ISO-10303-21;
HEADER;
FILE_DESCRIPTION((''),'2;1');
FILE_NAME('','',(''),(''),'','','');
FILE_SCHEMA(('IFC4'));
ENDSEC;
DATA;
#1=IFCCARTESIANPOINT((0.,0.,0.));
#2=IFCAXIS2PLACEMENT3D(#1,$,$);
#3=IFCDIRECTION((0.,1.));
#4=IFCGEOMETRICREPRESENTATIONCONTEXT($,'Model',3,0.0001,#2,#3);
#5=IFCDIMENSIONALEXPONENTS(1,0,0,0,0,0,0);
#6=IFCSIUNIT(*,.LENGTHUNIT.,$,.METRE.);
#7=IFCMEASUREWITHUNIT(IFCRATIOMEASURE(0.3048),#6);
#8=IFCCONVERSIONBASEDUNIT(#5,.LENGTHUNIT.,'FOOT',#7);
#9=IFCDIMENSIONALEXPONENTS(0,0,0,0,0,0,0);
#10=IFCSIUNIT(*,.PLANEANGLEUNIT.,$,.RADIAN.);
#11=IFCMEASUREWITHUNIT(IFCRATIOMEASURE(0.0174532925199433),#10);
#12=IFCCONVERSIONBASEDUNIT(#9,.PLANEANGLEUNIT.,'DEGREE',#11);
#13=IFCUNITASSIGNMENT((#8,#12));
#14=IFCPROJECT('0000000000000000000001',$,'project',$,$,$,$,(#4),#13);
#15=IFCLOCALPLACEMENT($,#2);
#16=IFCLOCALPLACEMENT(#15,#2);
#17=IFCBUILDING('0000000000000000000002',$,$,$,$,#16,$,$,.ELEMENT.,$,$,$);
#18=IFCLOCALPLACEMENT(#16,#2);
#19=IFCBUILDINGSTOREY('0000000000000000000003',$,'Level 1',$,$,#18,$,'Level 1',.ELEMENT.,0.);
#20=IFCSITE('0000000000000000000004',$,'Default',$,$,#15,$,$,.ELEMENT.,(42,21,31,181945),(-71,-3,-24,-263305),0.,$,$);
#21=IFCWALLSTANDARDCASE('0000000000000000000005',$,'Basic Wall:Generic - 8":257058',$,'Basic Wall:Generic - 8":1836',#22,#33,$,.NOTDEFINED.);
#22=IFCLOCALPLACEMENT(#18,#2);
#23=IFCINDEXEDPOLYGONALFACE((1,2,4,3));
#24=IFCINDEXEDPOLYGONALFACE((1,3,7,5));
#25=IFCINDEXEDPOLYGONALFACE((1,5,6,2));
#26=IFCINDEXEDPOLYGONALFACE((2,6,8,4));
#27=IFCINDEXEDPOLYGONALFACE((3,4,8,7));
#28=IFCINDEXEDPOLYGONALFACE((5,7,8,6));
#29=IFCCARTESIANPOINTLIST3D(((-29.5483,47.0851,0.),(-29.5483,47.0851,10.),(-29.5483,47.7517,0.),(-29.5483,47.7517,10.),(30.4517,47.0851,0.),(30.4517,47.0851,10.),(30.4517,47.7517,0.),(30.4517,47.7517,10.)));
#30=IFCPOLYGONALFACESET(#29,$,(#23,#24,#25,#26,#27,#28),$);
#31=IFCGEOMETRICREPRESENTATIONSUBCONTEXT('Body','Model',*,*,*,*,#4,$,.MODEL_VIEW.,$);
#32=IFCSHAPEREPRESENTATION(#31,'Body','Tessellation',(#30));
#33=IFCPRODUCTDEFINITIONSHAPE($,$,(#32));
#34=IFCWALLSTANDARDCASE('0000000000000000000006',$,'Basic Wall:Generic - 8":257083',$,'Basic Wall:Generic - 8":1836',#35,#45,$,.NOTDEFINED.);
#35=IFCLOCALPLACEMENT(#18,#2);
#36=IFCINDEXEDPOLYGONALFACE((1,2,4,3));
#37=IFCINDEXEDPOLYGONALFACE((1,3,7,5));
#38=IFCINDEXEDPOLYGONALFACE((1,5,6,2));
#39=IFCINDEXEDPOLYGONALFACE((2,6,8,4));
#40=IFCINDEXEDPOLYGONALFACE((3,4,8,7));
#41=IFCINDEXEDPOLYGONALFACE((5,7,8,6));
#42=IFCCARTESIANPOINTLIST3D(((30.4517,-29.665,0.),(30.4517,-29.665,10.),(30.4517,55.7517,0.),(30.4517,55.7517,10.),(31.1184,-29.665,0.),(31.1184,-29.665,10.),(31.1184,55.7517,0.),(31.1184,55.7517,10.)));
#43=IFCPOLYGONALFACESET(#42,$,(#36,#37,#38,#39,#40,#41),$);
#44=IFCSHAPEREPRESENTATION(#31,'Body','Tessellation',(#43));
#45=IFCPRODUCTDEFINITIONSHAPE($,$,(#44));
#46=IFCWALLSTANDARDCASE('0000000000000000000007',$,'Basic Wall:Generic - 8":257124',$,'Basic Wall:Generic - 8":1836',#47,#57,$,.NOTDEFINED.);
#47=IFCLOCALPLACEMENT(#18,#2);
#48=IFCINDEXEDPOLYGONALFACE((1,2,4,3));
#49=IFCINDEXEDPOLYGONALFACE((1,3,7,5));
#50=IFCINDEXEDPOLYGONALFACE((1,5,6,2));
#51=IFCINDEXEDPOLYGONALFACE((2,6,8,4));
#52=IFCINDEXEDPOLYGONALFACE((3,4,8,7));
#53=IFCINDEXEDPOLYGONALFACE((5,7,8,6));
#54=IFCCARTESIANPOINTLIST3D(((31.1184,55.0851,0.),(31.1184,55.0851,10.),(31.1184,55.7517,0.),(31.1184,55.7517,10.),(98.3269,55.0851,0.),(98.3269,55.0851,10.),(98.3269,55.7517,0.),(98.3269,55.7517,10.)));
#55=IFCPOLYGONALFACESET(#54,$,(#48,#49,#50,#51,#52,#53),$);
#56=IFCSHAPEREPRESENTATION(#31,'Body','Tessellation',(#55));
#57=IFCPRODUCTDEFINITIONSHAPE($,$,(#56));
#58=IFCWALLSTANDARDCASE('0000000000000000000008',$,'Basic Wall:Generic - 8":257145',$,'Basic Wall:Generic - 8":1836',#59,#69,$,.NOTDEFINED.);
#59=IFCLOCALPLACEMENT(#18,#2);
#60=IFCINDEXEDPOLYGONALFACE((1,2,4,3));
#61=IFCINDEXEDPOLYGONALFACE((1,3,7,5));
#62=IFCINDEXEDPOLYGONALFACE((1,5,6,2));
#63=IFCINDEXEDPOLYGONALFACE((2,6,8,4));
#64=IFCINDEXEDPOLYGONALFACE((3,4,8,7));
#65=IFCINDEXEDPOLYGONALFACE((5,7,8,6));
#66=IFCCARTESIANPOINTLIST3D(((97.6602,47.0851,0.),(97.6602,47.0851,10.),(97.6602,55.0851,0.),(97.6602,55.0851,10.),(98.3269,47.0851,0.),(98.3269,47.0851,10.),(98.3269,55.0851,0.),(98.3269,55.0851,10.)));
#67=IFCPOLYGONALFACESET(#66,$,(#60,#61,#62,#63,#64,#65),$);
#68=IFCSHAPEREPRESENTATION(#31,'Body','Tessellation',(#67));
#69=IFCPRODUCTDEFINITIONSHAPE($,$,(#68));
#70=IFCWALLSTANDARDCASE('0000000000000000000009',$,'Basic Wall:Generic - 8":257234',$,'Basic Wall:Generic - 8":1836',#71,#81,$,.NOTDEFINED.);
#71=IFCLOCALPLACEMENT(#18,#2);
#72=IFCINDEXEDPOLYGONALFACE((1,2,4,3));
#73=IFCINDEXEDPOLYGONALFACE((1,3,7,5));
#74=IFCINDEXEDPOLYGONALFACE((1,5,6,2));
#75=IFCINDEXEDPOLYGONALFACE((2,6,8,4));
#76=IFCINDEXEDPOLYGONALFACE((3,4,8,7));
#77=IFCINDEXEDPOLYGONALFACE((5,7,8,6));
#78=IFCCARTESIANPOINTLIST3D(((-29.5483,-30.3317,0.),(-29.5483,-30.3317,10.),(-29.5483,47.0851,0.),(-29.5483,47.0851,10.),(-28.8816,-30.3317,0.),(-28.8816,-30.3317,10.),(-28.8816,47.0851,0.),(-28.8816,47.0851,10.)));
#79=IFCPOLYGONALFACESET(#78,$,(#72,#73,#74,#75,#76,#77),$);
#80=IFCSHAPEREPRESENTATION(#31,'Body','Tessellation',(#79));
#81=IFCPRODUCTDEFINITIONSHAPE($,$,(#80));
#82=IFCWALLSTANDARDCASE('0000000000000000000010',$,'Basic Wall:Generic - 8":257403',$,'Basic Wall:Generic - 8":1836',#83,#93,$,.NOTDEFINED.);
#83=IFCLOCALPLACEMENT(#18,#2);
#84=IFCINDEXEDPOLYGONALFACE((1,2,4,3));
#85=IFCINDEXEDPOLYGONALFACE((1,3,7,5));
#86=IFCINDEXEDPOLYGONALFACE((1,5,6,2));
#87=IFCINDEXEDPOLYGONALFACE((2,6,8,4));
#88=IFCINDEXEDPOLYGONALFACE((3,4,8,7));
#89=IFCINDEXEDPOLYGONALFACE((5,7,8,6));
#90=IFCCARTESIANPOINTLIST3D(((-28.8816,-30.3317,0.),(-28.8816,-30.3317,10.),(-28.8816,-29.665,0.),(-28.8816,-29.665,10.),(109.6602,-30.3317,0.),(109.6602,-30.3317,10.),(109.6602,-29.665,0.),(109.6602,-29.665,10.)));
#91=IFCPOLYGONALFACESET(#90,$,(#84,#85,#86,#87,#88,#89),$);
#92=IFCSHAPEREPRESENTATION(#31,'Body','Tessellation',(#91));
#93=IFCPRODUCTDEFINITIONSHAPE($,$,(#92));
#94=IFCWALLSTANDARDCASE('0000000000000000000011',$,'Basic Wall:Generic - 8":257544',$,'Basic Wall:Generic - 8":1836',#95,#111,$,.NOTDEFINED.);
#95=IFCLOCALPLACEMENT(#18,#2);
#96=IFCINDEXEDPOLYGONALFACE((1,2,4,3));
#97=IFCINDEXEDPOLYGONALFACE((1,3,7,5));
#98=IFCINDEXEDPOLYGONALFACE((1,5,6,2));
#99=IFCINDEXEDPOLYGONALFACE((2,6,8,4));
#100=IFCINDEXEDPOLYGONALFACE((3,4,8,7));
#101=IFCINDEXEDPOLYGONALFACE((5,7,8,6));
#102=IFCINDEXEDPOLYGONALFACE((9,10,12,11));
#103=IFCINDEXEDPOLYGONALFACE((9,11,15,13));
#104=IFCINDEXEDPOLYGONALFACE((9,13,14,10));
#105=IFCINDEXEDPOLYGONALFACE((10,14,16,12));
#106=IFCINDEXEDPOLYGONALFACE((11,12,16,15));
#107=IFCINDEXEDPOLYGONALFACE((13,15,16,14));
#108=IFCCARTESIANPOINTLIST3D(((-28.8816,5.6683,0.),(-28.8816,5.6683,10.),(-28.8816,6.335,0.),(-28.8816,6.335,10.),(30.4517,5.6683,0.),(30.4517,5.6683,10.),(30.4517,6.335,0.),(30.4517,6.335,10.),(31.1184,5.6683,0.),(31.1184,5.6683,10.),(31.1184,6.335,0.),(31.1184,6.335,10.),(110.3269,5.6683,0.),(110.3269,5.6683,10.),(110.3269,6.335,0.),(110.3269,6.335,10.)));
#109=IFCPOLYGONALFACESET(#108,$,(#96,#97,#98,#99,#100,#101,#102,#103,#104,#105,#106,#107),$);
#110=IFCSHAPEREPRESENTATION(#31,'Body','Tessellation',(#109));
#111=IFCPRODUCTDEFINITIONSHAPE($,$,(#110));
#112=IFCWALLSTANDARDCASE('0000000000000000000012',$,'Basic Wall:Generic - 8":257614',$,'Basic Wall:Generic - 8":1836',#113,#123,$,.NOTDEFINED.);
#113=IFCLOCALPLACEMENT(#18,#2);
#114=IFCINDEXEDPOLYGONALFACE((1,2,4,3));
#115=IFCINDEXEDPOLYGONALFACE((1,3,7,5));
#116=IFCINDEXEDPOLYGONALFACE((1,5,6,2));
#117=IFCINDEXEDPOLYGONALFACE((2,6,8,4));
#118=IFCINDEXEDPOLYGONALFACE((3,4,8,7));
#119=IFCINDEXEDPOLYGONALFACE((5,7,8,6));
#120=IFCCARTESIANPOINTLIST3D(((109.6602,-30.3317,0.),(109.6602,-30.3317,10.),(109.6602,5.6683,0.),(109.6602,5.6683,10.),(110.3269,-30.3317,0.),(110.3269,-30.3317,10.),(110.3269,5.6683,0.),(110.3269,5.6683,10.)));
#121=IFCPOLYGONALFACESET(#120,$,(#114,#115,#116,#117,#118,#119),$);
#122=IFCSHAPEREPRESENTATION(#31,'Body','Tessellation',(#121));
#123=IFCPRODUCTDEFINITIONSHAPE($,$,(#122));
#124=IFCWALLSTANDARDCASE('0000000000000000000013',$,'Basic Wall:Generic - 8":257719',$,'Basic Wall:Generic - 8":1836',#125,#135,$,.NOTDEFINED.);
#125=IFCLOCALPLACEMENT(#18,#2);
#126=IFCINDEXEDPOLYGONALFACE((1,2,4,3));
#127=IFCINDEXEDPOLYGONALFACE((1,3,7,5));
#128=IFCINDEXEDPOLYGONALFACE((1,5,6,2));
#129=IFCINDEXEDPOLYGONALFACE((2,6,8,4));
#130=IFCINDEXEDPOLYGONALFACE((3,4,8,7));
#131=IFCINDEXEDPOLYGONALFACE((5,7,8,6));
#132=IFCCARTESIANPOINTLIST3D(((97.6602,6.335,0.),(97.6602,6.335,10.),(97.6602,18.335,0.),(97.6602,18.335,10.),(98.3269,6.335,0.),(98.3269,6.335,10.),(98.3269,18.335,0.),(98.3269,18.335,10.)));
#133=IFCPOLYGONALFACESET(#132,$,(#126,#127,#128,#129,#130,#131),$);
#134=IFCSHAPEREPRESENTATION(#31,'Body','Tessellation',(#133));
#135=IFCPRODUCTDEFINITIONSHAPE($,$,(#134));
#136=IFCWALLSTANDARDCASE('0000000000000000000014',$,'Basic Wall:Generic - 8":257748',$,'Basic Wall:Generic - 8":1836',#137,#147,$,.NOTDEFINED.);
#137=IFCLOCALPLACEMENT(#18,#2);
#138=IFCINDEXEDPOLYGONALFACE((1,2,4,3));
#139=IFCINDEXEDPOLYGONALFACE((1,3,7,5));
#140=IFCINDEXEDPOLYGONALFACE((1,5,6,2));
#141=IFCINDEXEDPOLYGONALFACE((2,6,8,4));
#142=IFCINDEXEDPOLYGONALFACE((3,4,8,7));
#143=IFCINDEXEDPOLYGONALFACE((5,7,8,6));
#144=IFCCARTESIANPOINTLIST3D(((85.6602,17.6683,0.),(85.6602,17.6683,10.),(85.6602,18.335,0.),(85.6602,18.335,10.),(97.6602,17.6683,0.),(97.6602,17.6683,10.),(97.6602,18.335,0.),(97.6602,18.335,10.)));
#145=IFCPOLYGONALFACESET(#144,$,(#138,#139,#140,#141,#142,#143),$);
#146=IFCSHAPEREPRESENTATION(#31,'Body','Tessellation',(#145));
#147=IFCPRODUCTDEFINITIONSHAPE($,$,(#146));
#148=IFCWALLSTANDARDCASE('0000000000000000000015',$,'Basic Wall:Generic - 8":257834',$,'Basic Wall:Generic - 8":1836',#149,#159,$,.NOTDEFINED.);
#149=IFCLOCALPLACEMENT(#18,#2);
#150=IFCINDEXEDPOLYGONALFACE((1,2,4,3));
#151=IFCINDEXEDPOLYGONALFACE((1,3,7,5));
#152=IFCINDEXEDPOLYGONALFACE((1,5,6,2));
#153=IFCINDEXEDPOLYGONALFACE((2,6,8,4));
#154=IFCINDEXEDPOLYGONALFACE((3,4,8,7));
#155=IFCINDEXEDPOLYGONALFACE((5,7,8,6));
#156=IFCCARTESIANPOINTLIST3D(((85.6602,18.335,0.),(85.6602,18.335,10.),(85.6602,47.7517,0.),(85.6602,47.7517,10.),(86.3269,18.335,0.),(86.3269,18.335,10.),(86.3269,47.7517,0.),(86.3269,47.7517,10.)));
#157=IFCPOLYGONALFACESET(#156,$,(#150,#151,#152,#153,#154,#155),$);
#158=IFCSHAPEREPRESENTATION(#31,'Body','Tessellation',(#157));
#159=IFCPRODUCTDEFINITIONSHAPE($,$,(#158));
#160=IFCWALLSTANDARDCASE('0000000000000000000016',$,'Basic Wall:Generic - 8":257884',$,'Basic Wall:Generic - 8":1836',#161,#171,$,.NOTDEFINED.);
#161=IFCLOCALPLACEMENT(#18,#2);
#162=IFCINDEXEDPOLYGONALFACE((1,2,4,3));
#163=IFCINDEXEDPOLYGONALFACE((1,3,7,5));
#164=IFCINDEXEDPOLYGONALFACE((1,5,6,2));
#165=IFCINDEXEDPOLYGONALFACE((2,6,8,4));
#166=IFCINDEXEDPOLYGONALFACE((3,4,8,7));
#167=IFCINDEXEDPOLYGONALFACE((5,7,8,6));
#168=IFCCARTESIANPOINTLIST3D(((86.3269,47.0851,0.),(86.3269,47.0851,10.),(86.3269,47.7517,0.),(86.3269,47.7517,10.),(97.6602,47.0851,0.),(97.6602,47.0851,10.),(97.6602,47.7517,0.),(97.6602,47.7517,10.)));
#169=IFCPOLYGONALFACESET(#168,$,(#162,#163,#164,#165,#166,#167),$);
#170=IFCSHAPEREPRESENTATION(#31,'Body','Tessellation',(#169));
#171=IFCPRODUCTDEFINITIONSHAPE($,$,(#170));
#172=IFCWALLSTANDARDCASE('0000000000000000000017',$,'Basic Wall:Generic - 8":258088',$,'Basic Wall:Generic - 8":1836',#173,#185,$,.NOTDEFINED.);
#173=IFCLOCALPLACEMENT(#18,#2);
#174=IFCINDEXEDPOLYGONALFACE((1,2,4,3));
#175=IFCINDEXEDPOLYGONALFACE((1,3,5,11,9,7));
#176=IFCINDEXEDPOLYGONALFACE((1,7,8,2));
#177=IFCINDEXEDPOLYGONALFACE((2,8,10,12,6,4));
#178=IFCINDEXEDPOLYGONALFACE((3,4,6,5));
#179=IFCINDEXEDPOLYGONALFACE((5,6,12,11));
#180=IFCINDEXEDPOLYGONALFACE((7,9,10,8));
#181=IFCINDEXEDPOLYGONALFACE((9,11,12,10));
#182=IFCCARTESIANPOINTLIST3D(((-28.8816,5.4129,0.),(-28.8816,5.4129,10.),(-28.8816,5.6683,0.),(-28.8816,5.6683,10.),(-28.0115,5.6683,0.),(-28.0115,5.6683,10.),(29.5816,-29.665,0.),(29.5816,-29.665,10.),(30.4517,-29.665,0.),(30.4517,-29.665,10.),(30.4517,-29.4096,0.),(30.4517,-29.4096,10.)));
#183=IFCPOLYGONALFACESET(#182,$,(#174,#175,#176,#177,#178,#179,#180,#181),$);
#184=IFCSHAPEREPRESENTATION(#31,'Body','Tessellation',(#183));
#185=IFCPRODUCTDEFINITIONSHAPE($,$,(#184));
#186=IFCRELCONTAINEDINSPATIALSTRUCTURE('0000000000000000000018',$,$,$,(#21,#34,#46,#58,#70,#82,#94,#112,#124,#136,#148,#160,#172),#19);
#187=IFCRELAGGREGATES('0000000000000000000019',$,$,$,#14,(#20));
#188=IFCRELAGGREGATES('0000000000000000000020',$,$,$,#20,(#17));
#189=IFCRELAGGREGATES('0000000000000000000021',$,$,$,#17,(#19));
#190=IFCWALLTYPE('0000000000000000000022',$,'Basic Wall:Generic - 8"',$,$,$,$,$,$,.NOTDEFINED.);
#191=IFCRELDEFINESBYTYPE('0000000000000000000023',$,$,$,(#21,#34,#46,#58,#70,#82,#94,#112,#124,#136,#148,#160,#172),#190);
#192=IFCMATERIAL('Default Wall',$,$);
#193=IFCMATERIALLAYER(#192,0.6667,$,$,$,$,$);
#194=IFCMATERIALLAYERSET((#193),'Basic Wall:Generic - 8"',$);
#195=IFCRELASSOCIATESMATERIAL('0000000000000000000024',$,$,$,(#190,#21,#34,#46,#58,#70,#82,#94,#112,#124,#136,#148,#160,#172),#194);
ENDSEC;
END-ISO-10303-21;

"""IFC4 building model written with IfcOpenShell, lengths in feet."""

from ifc_helpers import new_model, entity, si_unit, converted_unit, direction, frame, frame_2d, origin, place, context, subcontext, project, spatial, polyline, rectangle, outline, extrude, material, layer, layer_set, layer_usage, type_object, element, save


model = new_model("IFC4")

# Units and contexts
model_context = context("Model", 3, precision=0.0001, world=origin(), true_north=direction((0.0, 1.0)))
body_context = subcontext(model_context, "Body", "Model", "MODEL_VIEW")
ifc_project = project(units=[converted_unit("LENGTHUNIT", "FOOT", entity("IfcRatioMeasure", 0.3048), si_unit("LENGTHUNIT", "METRE"), dimensions=[1, 0, 0, 0, 0, 0, 0]), converted_unit("PLANEANGLEUNIT", "DEGREE", entity("IfcRatioMeasure", 0.0174532925199433), si_unit("PLANEANGLEUNIT", "RADIAN"), dimensions=[0, 0, 0, 0, 0, 0, 0])], contexts=[model_context])

# Site, building, storey
site_placement = place(None, origin())
site = spatial("IfcSite", under=ifc_project, at=site_placement, Name="Default", CompositionType="ELEMENT", RefLatitude=(42, 21, 31, 181945), RefLongitude=(-71, -3, -24, -263305), RefElevation=0.0)
building_placement = place(site_placement, origin())
building = spatial("IfcBuilding", under=site, at=building_placement, CompositionType="ELEMENT")
storey_placement = place(building_placement, origin())
storey = spatial("IfcBuildingStorey", under=building, at=storey_placement, Name="Level 1", LongName="Level 1", CompositionType="ELEMENT", Elevation=0.0)

# Walls
ifc_material = material(Name="Default Wall")
ifc_layer = layer(ifc_material, 0.6667)
ifc_layer_set = layer_set([ifc_layer], Name="Basic Wall:Generic - 8\"")
ifc_layer_usage_1 = layer_usage(ifc_layer_set, "AXIS2", "NEGATIVE", 0.3333)
wall_type = type_object("IfcWallType", Name="Basic Wall:Generic - 8\"", PredefinedType="NOTDEFINED", material=ifc_layer_set)
wall_1_placement = place(storey_placement, frame((-29.5483, 47.4184, 0.0)))
element("IfcWallStandardCase", 1, at=wall_1_placement, inside=storey, type_object=wall_type, material=ifc_layer_usage_1, Name="Basic Wall:Generic - 8\":257058", ObjectType="Basic Wall:Generic - 8\":1836", PredefinedType="NOTDEFINED", context=body_context, shape_type="SweptSolid", body=[
    extrude(rectangle(XDim=60.0, YDim=0.6667, at=frame_2d((30.0, 0.0), x_axis=(-1.0, 0.0))), origin(), (0.0, 0.0, 1.0), 10.0),
])
ifc_layer_usage_2 = layer_usage(ifc_layer_set, "AXIS2", "NEGATIVE", 0.3333)
wall_2_placement = place(storey_placement, frame((30.785, -29.665, 0.0), z_axis=(0.0, 0.0, 1.0), x_axis=(0.0, 1.0, 0.0)))
element("IfcWallStandardCase", 2, at=wall_2_placement, inside=storey, type_object=wall_type, material=ifc_layer_usage_2, Name="Basic Wall:Generic - 8\":257083", ObjectType="Basic Wall:Generic - 8\":1836", PredefinedType="NOTDEFINED", context=body_context, shape_type="SweptSolid", body=[
    extrude(rectangle(XDim=85.4167, YDim=0.6667, at=frame_2d((42.7084, 0.0), x_axis=(-1.0, 0.0))), origin(), (0.0, 0.0, 1.0), 10.0),
])
ifc_layer_usage_3 = layer_usage(ifc_layer_set, "AXIS2", "NEGATIVE", 0.3333)
wall_3_placement = place(storey_placement, frame((31.1184, 55.4184, 0.0)))
element("IfcWallStandardCase", 3, at=wall_3_placement, inside=storey, type_object=wall_type, material=ifc_layer_usage_3, Name="Basic Wall:Generic - 8\":257124", ObjectType="Basic Wall:Generic - 8\":1836", PredefinedType="NOTDEFINED", context=body_context, shape_type="SweptSolid", body=[
    extrude(rectangle(XDim=67.2085, YDim=0.6667, at=frame_2d((33.6043, 0.0), x_axis=(-1.0, 0.0))), origin(), (0.0, 0.0, 1.0), 10.0),
])
ifc_layer_usage_4 = layer_usage(ifc_layer_set, "AXIS2", "NEGATIVE", 0.3333)
wall_4_placement = place(storey_placement, frame((97.9936, 55.0851, 0.0), z_axis=(0.0, 0.0, 1.0), x_axis=(0.0, -1.0, 0.0)))
element("IfcWallStandardCase", 4, at=wall_4_placement, inside=storey, type_object=wall_type, material=ifc_layer_usage_4, Name="Basic Wall:Generic - 8\":257145", ObjectType="Basic Wall:Generic - 8\":1836", PredefinedType="NOTDEFINED", context=body_context, shape_type="SweptSolid", body=[
    extrude(rectangle(XDim=8.0, YDim=0.6667, at=frame_2d((4.0, 0.0), x_axis=(-1.0, 0.0))), origin(), (0.0, 0.0, 1.0), 10.0),
])
ifc_layer_usage_5 = layer_usage(ifc_layer_set, "AXIS2", "NEGATIVE", 0.3333)
wall_5_placement = place(storey_placement, frame((-29.215, -30.3317, 0.0), z_axis=(0.0, 0.0, 1.0), x_axis=(0.0, 1.0, 0.0)))
element("IfcWallStandardCase", 5, at=wall_5_placement, inside=storey, type_object=wall_type, material=ifc_layer_usage_5, Name="Basic Wall:Generic - 8\":257234", ObjectType="Basic Wall:Generic - 8\":1836", PredefinedType="NOTDEFINED", context=body_context, shape_type="SweptSolid", body=[
    extrude(rectangle(XDim=77.4167, YDim=0.6667, at=frame_2d((38.7084, 0.0), x_axis=(-1.0, 0.0))), origin(), (0.0, 0.0, 1.0), 10.0),
])
ifc_layer_usage_6 = layer_usage(ifc_layer_set, "AXIS2", "NEGATIVE", 0.3333)
wall_6_placement = place(storey_placement, frame((-28.8816, -29.9983, 0.0)))
element("IfcWallStandardCase", 6, at=wall_6_placement, inside=storey, type_object=wall_type, material=ifc_layer_usage_6, Name="Basic Wall:Generic - 8\":257403", ObjectType="Basic Wall:Generic - 8\":1836", PredefinedType="NOTDEFINED", context=body_context, shape_type="SweptSolid", body=[
    extrude(rectangle(XDim=138.5419, YDim=0.6667, at=frame_2d((69.2709, 0.0), x_axis=(-1.0, 0.0))), origin(), (0.0, 0.0, 1.0), 10.0),
])

# Wall, opening
ifc_layer_usage_7 = layer_usage(ifc_layer_set, "AXIS2", "NEGATIVE", 0.3333)
wall_7_placement = place(storey_placement, frame((-28.8816, 6.0017, 0.0)))
wall_7 = element("IfcWallStandardCase", 7, at=wall_7_placement, inside=storey, type_object=wall_type, material=ifc_layer_usage_7, Name="Basic Wall:Generic - 8\":257544", ObjectType="Basic Wall:Generic - 8\":1836", PredefinedType="NOTDEFINED", context=body_context, shape_type="SweptSolid", body=[
    extrude(rectangle(XDim=139.2085, YDim=0.6667, at=frame_2d((69.6043, 0.0), x_axis=(-1.0, 0.0))), origin(), (0.0, 0.0, 1.0), 10.0),
])
opening_placement = place(storey_placement, frame((-28.8816, 6.0017, 0.0)))
element("IfcOpeningElement", 8, at=opening_placement, cuts=wall_7, ObjectType="Opening", PredefinedType="OPENING", context=body_context, shape_type="SweptSolid", body=[
    extrude(rectangle(XDim=10.0, YDim=0.6667, at=frame_2d((0.0, 0.0), x_axis=(1.0, 0.0))), frame((59.3333, 0.0, 5.0), z_axis=(1.0, 0.0, 0.0), x_axis=(0.0, 0.0, -1.0)), (0.0, 0.0, 1.0), 0.6667),
])

# Walls
ifc_layer_usage_8 = layer_usage(ifc_layer_set, "AXIS2", "NEGATIVE", 0.3333)
wall_8_placement = place(storey_placement, frame((109.9936, 5.6683, 0.0), z_axis=(0.0, 0.0, 1.0), x_axis=(0.0, -1.0, 0.0)))
element("IfcWallStandardCase", 9, at=wall_8_placement, inside=storey, type_object=wall_type, material=ifc_layer_usage_8, Name="Basic Wall:Generic - 8\":257614", ObjectType="Basic Wall:Generic - 8\":1836", PredefinedType="NOTDEFINED", context=body_context, shape_type="SweptSolid", body=[
    extrude(rectangle(XDim=36.0, YDim=0.6667, at=frame_2d((18.0, 0.0), x_axis=(-1.0, 0.0))), origin(), (0.0, 0.0, 1.0), 10.0),
])
ifc_layer_usage_9 = layer_usage(ifc_layer_set, "AXIS2", "NEGATIVE", 0.3333)
wall_9_placement = place(storey_placement, frame((97.9936, 6.335, 0.0), z_axis=(0.0, 0.0, 1.0), x_axis=(0.0, 1.0, 0.0)))
element("IfcWallStandardCase", 10, at=wall_9_placement, inside=storey, type_object=wall_type, material=ifc_layer_usage_9, Name="Basic Wall:Generic - 8\":257719", ObjectType="Basic Wall:Generic - 8\":1836", PredefinedType="NOTDEFINED", context=body_context, shape_type="SweptSolid", body=[
    extrude(rectangle(XDim=12.0, YDim=0.6667, at=frame_2d((6.0, 0.0), x_axis=(-1.0, 0.0))), origin(), (0.0, 0.0, 1.0), 10.0),
])
ifc_layer_usage_10 = layer_usage(ifc_layer_set, "AXIS2", "NEGATIVE", 0.3333)
wall_10_placement = place(storey_placement, frame((97.6602, 18.0017, 0.0), z_axis=(0.0, 0.0, 1.0), x_axis=(-1.0, 0.0, 0.0)))
element("IfcWallStandardCase", 11, at=wall_10_placement, inside=storey, type_object=wall_type, material=ifc_layer_usage_10, Name="Basic Wall:Generic - 8\":257748", ObjectType="Basic Wall:Generic - 8\":1836", PredefinedType="NOTDEFINED", context=body_context, shape_type="SweptSolid", body=[
    extrude(rectangle(XDim=12.0, YDim=0.6667, at=frame_2d((6.0, 0.0), x_axis=(-1.0, 0.0))), origin(), (0.0, 0.0, 1.0), 10.0),
])
ifc_layer_usage_11 = layer_usage(ifc_layer_set, "AXIS2", "NEGATIVE", 0.3333)
wall_11_placement = place(storey_placement, frame((85.9936, 47.7517, 0.0), z_axis=(0.0, 0.0, 1.0), x_axis=(0.0, -1.0, 0.0)))
element("IfcWallStandardCase", 12, at=wall_11_placement, inside=storey, type_object=wall_type, material=ifc_layer_usage_11, Name="Basic Wall:Generic - 8\":257834", ObjectType="Basic Wall:Generic - 8\":1836", PredefinedType="NOTDEFINED", context=body_context, shape_type="SweptSolid", body=[
    extrude(rectangle(XDim=29.4167, YDim=0.6667, at=frame_2d((14.7084, 0.0), x_axis=(-1.0, 0.0))), origin(), (0.0, 0.0, 1.0), 10.0),
])
ifc_layer_usage_12 = layer_usage(ifc_layer_set, "AXIS2", "NEGATIVE", 0.3333)
wall_12_placement = place(storey_placement, frame((86.3269, 47.4184, 0.0)))
element("IfcWallStandardCase", 13, at=wall_12_placement, inside=storey, type_object=wall_type, material=ifc_layer_usage_12, Name="Basic Wall:Generic - 8\":257884", ObjectType="Basic Wall:Generic - 8\":1836", PredefinedType="NOTDEFINED", context=body_context, shape_type="SweptSolid", body=[
    extrude(rectangle(XDim=11.3333, YDim=0.6667, at=frame_2d((5.6667, 0.0), x_axis=(-1.0, 0.0))), origin(), (0.0, 0.0, 1.0), 10.0),
])
ifc_layer_usage_13 = layer_usage(ifc_layer_set, "AXIS2", "NEGATIVE", 0.3333)
wall_13_placement = place(storey_placement, frame((-28.7101, 5.6988, 0.0), z_axis=(0.0, 0.0, 1.0), x_axis=(0.857493, -0.514496, 0.0)))
element("IfcWallStandardCase", 14, at=wall_13_placement, inside=storey, type_object=wall_type, material=ifc_layer_usage_13, Name="Basic Wall:Generic - 8\":258088", ObjectType="Basic Wall:Generic - 8\":1836", PredefinedType="NOTDEFINED", context=body_context, shape_type="SweptSolid", body=[
    extrude(outline(polyline([(68.1793, -0.3333), (68.9254, 0.1143), (68.794, 0.3333), (0.6147, 0.3333), (-0.1314, -0.1143), (0.0, -0.3333), (68.1793, -0.3333)])), origin(), (0.0, 0.0, 1.0), 10.0),
])

save(model, "model.ifc")
